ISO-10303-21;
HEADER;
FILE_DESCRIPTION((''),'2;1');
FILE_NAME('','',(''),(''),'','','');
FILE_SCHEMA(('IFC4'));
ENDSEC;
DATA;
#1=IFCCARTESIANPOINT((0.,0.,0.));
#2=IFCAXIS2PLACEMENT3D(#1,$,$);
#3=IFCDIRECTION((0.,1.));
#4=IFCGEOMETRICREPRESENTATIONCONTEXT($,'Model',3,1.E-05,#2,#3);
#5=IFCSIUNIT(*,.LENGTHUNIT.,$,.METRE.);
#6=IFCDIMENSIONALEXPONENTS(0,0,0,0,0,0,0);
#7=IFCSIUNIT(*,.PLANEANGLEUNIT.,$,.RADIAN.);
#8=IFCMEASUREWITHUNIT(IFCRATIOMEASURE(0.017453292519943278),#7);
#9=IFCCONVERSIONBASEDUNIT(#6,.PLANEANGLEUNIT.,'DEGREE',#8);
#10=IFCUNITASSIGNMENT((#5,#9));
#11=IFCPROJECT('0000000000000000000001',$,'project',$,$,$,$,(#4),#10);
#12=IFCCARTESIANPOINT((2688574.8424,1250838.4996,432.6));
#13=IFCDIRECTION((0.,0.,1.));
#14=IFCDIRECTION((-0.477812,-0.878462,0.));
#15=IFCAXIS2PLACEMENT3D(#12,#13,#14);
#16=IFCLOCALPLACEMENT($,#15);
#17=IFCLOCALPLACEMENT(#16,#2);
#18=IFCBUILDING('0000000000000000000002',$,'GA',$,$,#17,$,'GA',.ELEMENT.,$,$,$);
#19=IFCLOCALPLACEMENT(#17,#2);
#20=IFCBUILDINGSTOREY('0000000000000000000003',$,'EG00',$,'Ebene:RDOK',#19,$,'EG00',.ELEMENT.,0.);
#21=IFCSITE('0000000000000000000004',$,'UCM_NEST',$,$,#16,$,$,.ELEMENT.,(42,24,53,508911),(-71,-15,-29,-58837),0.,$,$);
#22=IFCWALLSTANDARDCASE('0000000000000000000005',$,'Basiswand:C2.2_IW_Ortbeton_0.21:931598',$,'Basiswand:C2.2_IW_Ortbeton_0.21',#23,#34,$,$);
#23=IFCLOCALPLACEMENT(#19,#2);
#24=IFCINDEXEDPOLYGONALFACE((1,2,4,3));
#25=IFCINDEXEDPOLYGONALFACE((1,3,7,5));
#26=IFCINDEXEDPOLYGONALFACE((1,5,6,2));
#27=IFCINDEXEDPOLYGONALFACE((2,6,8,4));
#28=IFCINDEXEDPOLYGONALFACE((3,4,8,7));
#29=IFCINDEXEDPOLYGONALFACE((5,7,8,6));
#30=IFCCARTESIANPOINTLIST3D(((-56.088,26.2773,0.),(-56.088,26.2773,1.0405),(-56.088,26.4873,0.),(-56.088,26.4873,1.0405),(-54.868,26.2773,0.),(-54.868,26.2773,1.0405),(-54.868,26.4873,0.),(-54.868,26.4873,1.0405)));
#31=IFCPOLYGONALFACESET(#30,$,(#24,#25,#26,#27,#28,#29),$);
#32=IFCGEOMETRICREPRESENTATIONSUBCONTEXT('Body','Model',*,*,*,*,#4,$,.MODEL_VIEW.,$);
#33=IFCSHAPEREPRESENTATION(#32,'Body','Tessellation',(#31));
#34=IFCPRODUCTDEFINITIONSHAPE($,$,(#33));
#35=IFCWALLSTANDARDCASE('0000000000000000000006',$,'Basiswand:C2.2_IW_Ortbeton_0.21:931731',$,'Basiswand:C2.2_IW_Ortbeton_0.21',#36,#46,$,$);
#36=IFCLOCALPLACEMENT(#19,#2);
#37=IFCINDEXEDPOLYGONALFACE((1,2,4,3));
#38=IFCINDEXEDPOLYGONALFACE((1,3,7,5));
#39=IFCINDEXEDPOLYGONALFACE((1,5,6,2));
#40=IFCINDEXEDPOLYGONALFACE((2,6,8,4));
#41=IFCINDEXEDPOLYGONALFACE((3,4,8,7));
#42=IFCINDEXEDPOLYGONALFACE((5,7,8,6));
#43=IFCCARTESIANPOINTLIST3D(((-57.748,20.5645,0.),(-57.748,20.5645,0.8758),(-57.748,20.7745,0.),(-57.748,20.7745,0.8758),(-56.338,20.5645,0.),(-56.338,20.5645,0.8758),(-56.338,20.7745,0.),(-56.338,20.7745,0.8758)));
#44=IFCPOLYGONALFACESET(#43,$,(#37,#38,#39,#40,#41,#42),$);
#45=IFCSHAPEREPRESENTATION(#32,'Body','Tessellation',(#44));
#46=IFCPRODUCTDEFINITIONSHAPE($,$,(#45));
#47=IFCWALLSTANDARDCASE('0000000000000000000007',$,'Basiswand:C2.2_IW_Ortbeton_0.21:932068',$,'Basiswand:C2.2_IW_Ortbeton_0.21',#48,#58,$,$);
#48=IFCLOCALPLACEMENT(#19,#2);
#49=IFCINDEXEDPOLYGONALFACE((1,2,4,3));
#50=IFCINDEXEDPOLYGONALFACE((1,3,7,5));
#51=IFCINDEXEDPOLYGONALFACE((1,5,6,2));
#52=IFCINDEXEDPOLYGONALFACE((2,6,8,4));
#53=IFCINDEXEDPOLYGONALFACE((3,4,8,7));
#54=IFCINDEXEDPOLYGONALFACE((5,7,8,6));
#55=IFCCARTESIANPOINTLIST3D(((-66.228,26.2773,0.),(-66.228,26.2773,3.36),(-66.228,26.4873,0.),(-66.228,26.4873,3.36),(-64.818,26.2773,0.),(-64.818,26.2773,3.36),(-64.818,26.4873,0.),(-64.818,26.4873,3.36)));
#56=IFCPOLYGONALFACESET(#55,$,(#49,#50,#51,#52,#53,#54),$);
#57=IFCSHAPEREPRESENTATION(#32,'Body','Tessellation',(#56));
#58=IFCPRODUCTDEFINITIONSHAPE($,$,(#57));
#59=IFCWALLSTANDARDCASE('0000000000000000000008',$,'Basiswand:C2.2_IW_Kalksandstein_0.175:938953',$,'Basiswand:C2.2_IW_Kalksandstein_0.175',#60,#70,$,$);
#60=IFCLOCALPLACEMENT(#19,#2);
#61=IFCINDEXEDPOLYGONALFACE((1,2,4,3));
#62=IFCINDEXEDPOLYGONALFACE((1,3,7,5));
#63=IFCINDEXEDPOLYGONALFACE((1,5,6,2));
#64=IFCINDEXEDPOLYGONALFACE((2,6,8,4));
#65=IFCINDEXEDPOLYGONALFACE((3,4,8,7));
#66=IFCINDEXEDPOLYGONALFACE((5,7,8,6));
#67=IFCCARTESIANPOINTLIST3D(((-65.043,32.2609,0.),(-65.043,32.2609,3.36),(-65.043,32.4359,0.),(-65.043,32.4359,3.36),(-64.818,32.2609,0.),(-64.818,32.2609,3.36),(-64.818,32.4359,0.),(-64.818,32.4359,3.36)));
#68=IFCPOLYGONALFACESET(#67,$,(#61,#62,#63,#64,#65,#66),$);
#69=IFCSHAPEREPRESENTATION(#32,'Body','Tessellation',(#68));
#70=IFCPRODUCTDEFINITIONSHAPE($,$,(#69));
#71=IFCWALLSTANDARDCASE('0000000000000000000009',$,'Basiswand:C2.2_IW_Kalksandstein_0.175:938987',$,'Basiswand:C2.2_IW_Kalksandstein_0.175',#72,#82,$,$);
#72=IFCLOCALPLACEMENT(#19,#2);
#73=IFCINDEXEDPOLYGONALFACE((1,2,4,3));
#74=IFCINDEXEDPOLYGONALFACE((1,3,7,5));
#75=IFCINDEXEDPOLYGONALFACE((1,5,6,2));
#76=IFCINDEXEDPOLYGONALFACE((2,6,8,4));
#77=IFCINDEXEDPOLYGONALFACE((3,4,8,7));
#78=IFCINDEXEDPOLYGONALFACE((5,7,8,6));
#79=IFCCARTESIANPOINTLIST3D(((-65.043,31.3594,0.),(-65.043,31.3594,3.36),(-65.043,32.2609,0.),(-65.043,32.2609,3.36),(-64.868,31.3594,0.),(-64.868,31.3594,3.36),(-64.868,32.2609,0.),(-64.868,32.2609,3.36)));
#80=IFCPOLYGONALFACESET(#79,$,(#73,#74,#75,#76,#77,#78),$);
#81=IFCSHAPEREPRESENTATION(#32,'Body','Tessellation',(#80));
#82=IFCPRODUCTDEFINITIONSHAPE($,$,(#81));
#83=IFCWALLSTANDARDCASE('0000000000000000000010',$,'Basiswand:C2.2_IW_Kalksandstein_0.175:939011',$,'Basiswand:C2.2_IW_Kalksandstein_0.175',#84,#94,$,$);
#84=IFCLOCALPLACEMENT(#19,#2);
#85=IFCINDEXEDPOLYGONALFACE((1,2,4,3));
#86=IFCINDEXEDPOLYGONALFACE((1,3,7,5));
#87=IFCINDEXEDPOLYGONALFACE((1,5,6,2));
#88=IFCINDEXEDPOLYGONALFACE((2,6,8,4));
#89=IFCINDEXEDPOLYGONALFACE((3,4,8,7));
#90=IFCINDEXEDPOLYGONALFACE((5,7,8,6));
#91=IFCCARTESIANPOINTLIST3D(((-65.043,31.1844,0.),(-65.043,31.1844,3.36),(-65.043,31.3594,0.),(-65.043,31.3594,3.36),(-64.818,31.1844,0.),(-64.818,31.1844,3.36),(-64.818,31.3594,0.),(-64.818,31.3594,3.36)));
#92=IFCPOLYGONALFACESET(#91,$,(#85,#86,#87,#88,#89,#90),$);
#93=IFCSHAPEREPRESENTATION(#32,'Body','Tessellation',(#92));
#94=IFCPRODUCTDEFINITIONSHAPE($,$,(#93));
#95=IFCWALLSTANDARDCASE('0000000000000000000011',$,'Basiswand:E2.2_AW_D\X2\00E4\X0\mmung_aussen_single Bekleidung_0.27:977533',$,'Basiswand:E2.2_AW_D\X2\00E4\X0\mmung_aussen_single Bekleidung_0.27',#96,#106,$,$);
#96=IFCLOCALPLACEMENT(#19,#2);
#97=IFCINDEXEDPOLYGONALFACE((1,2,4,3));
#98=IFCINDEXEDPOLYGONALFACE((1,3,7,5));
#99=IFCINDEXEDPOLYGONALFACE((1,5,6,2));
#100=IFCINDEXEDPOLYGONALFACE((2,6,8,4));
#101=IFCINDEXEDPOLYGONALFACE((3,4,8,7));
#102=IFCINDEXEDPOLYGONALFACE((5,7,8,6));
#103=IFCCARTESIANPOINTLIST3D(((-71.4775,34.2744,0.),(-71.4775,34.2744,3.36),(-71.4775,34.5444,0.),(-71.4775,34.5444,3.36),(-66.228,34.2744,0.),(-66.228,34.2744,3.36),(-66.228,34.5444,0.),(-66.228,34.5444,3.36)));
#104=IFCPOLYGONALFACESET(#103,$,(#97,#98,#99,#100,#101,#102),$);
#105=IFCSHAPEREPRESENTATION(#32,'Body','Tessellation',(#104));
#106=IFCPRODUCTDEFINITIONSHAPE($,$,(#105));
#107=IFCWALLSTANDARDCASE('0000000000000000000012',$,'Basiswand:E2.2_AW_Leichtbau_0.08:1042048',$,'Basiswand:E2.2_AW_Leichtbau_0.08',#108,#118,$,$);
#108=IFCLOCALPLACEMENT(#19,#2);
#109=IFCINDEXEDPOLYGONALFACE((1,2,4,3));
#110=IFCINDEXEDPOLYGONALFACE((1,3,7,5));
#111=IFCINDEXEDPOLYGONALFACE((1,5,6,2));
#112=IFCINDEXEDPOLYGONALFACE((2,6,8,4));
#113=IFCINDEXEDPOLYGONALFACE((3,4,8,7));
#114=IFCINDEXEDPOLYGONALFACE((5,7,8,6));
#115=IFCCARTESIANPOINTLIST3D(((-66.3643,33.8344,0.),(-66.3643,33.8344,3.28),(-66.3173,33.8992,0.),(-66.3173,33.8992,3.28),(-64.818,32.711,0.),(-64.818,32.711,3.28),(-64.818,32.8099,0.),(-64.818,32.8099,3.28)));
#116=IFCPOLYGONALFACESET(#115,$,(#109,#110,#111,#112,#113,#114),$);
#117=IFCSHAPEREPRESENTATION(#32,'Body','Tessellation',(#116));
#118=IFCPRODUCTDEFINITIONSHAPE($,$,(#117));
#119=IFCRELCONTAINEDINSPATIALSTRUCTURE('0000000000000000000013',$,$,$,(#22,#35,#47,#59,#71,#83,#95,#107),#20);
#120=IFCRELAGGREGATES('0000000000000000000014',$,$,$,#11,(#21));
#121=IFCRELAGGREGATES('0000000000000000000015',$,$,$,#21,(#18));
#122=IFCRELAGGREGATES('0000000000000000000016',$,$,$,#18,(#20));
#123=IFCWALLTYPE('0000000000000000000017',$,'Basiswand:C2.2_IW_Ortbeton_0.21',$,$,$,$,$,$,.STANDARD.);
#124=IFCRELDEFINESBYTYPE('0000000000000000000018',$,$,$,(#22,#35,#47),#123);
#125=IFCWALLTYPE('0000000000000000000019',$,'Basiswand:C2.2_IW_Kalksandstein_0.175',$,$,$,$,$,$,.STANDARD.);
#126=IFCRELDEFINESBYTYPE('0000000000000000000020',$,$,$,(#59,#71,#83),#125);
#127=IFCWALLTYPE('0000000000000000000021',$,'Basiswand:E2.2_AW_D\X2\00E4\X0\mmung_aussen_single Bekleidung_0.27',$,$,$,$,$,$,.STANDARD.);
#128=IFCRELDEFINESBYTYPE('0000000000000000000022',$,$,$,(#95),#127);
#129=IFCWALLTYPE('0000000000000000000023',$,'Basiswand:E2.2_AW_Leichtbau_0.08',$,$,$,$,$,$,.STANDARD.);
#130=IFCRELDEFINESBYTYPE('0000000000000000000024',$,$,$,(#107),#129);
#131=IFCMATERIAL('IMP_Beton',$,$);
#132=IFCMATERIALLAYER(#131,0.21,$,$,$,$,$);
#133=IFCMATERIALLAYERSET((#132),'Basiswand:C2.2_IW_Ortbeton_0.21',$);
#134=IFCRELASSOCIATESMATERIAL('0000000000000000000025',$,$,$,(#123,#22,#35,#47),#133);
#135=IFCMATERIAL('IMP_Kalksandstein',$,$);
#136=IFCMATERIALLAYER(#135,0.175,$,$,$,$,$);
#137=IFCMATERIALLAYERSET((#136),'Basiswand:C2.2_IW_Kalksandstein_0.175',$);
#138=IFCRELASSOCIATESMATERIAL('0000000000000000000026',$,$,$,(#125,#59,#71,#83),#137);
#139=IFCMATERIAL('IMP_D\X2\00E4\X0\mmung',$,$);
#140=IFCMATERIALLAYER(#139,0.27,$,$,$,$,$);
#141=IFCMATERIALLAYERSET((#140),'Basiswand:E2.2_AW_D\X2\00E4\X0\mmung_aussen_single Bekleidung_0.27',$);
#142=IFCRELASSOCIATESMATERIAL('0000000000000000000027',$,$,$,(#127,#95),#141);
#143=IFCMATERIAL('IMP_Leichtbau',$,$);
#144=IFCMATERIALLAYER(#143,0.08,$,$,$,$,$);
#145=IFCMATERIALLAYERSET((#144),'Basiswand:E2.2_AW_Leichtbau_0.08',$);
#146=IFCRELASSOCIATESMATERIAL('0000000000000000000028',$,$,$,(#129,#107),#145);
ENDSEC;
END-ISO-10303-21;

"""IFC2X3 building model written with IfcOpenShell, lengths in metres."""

from ifc_helpers import new_model, entity, si_unit, converted_unit, direction, frame, frame_2d, origin, place, context, subcontext, project, spatial, polyline, rectangle, outline, extrude, clip, bounded_halfspace, material, layer, layer_set, layer_usage, type_object, element, save


model = new_model("IFC2X3")

# Units and contexts
model_context = context("Model", 3, precision=1e-05, world=origin(), true_north=direction((0.0, 1.0)))
body_context = subcontext(model_context, "Body", "Model", "MODEL_VIEW")
ifc_project = project(units=[si_unit("LENGTHUNIT", "METRE"), converted_unit("PLANEANGLEUNIT", "DEGREE", entity("IfcRatioMeasure", 0.017453292519943278), si_unit("PLANEANGLEUNIT", "RADIAN"), dimensions=[0, 0, 0, 0, 0, 0, 0])], contexts=[model_context])

# Site, building, storey
site_placement = place(None, frame((2688574.8424, 1250838.4996, 432.6), z_axis=(0.0, 0.0, 1.0), x_axis=(-0.477812, -0.878462, 0.0)))
site = spatial("IfcSite", under=ifc_project, at=site_placement, Name="UCM_NEST", CompositionType="ELEMENT", RefLatitude=(42, 24, 53, 508911), RefLongitude=(-71, -15, -29, -58837), RefElevation=0.0)
building_placement = place(site_placement, origin())
building = spatial("IfcBuilding", under=site, at=building_placement, Name="GA", LongName="GA", CompositionType="ELEMENT")
storey_placement = place(building_placement, origin())
storey = spatial("IfcBuildingStorey", under=building, at=storey_placement, Name="EG00", ObjectType="Ebene:RDOK", LongName="EG00", CompositionType="ELEMENT", Elevation=0.0)

# Shared definitions
ifc_material_1 = material(Name="IMP_Dämmung")
ifc_material_2 = material(Name="IMP_Beton")

# Walls
ifc_layer_1 = layer(ifc_material_2, 0.21)
ifc_layer_set_1 = layer_set([ifc_layer_1], Name="Basiswand:C2.2_IW_Ortbeton_0.21")
ifc_layer_usage_1 = layer_usage(ifc_layer_set_1, "AXIS2", "NEGATIVE", 0.105)
wall_type_1 = type_object("IfcWallType", Name="Basiswand:C2.2_IW_Ortbeton_0.21", PredefinedType="STANDARD", material=ifc_layer_set_1)
wall_1_placement = place(storey_placement, frame((-54.868, 26.3823, 0.0), z_axis=(0.0, 0.0, 1.0), x_axis=(-1.0, 0.0, 0.0)))
element("IfcWallStandardCase", 1, at=wall_1_placement, inside=storey, type_object=wall_type_1, material=ifc_layer_usage_1, Name="Basiswand:C2.2_IW_Ortbeton_0.21:931598", ObjectType="Basiswand:C2.2_IW_Ortbeton_0.21", context=body_context, shape_type="SweptSolid", body=[
    extrude(rectangle(XDim=1.22, YDim=0.21, at=frame_2d((0.61, 0.0), x_axis=(-1.0, 0.0))), origin(), (0.0, 0.0, 1.0), 1.0405),
])
wall_2_placement = place(storey_placement, frame((-56.338, 20.6695, 0.0), z_axis=(0.0, 0.0, 1.0), x_axis=(-1.0, 0.0, 0.0)))
element("IfcWallStandardCase", 2, at=wall_2_placement, inside=storey, type_object=wall_type_1, material=ifc_layer_usage_1, Name="Basiswand:C2.2_IW_Ortbeton_0.21:931731", ObjectType="Basiswand:C2.2_IW_Ortbeton_0.21", context=body_context, shape_type="SweptSolid", body=[
    extrude(rectangle(XDim=1.41, YDim=0.21, at=frame_2d((0.705, 0.0), x_axis=(-1.0, 0.0))), origin(), (0.0, 0.0, 1.0), 0.8758),
])
wall_3_placement = place(storey_placement, frame((-64.818, 26.3823, 0.0), z_axis=(0.0, 0.0, 1.0), x_axis=(-1.0, 0.0, 0.0)))
element("IfcWallStandardCase", 3, at=wall_3_placement, inside=storey, type_object=wall_type_1, material=ifc_layer_usage_1, Name="Basiswand:C2.2_IW_Ortbeton_0.21:932068", ObjectType="Basiswand:C2.2_IW_Ortbeton_0.21", context=body_context, shape_type="SweptSolid", body=[
    extrude(rectangle(XDim=1.41, YDim=0.21, at=frame_2d((0.705, 0.0), x_axis=(-1.0, 0.0))), origin(), (0.0, 0.0, 1.0), 3.36),
])
ifc_material_3 = material(Name="IMP_Kalksandstein")
ifc_layer_2 = layer(ifc_material_3, 0.175)
ifc_layer_set_2 = layer_set([ifc_layer_2], Name="Basiswand:C2.2_IW_Kalksandstein_0.175")
ifc_layer_usage_2 = layer_usage(ifc_layer_set_2, "AXIS2", "NEGATIVE", 0.0875)
wall_type_2 = type_object("IfcWallType", Name="Basiswand:C2.2_IW_Kalksandstein_0.175", PredefinedType="STANDARD", material=ifc_layer_set_2)
wall_4_placement = place(storey_placement, frame((-64.818, 32.3484, 0.0), z_axis=(0.0, 0.0, 1.0), x_axis=(-1.0, 0.0, 0.0)))
element("IfcWallStandardCase", 4, at=wall_4_placement, inside=storey, type_object=wall_type_2, material=ifc_layer_usage_2, Name="Basiswand:C2.2_IW_Kalksandstein_0.175:938953", ObjectType="Basiswand:C2.2_IW_Kalksandstein_0.175", context=body_context, shape_type="SweptSolid", body=[
    extrude(rectangle(XDim=0.225, YDim=0.175, at=frame_2d((0.1125, 0.0), x_axis=(-1.0, 0.0))), origin(), (0.0, 0.0, 1.0), 3.36),
])
wall_5_placement = place(storey_placement, frame((-64.9555, 32.2609, 0.0), z_axis=(0.0, 0.0, 1.0), x_axis=(0.0, -1.0, 0.0)))
element("IfcWallStandardCase", 5, at=wall_5_placement, inside=storey, type_object=wall_type_2, material=ifc_layer_usage_2, Name="Basiswand:C2.2_IW_Kalksandstein_0.175:938987", ObjectType="Basiswand:C2.2_IW_Kalksandstein_0.175", context=body_context, shape_type="SweptSolid", body=[
    extrude(rectangle(XDim=0.9015, YDim=0.175, at=frame_2d((0.4507, 0.0), x_axis=(-1.0, 0.0))), origin(), (0.0, 0.0, 1.0), 3.36),
])
wall_6_placement = place(storey_placement, frame((-65.043, 31.2719, 0.0)))
element("IfcWallStandardCase", 6, at=wall_6_placement, inside=storey, type_object=wall_type_2, material=ifc_layer_usage_2, Name="Basiswand:C2.2_IW_Kalksandstein_0.175:939011", ObjectType="Basiswand:C2.2_IW_Kalksandstein_0.175", context=body_context, shape_type="SweptSolid", body=[
    extrude(rectangle(XDim=0.225, YDim=0.175, at=frame_2d((0.1125, 0.0), x_axis=(-1.0, 0.0))), origin(), (0.0, 0.0, 1.0), 3.36),
])
ifc_layer_3 = layer(ifc_material_1, 0.27)
ifc_layer_set_3 = layer_set([ifc_layer_3], Name="Basiswand:E2.2_AW_Dämmung_aussen_single Bekleidung_0.27")
ifc_layer_usage_3 = layer_usage(ifc_layer_set_3, "AXIS2", "NEGATIVE", 0.135)
wall_type_3 = type_object("IfcWallType", Name="Basiswand:E2.2_AW_Dämmung_aussen_single Bekleidung_0.27", PredefinedType="STANDARD", material=ifc_layer_set_3)
wall_7_placement = place(storey_placement, frame((-66.228, 34.4094, 0.0), z_axis=(0.0, 0.0, 1.0), x_axis=(-1.0, 0.0, 0.0)))
element("IfcWallStandardCase", 7, at=wall_7_placement, inside=storey, type_object=wall_type_3, material=ifc_layer_usage_3, Name="Basiswand:E2.2_AW_Dämmung_aussen_single Bekleidung_0.27:977533", ObjectType="Basiswand:E2.2_AW_Dämmung_aussen_single Bekleidung_0.27", context=body_context, shape_type="SweptSolid", body=[
    extrude(rectangle(XDim=5.2494, YDim=0.27, at=frame_2d((2.6247, 0.0), x_axis=(-1.0, 0.0))), origin(), (0.0, 0.0, 1.0), 3.36),
])

# Wall
ifc_material_4 = material(Name="IMP_Leichtbau")
ifc_layer_4 = layer(ifc_material_4, 0.08)
ifc_layer_set_4 = layer_set([ifc_layer_4], Name="Basiswand:E2.2_AW_Leichtbau_0.08")
ifc_layer_usage_4 = layer_usage(ifc_layer_set_4, "AXIS2", "NEGATIVE", 0.04)
wall_type_4 = type_object("IfcWallType", Name="Basiswand:E2.2_AW_Leichtbau_0.08", PredefinedType="STANDARD", material=ifc_layer_set_4)
wall_8_placement = place(storey_placement, frame((-66.3408, 33.8668, 0.0), z_axis=(0.0, 0.0, 1.0), x_axis=(0.809017, -0.587785, 0.0)))
element("IfcWallStandardCase", 8, at=wall_8_placement, inside=storey, type_object=wall_type_4, material=ifc_layer_usage_4, Name="Basiswand:E2.2_AW_Leichtbau_0.08:1042048", ObjectType="Basiswand:E2.2_AW_Leichtbau_0.08", context=body_context, shape_type="Clipping", body=[
    clip(extrude(outline(polyline([(1.9113, -0.04), (1.8532, 0.04), (0.0, 0.04), (0.0, -0.04), (1.9113, -0.04)])), origin(), (0.0, 0.0, 1.0), 3.28), bounded_halfspace(frame((0.0, -0.04, 3.28), z_axis=(0.0, 0.0, -1.0), x_axis=(-0.809017, -0.587785, 0.0)), True, frame((0.0, -0.04, 3.28), z_axis=(0.0, 0.0, -1.0), x_axis=(-0.809017, -0.587785, 0.0)), polyline([(0.0, 0.0), (-0.047, 0.0647), (-1.5463, -1.0246), (-1.5463, -1.1234), (0.0, 0.0)]))),
])

save(model, "model.ifc")
